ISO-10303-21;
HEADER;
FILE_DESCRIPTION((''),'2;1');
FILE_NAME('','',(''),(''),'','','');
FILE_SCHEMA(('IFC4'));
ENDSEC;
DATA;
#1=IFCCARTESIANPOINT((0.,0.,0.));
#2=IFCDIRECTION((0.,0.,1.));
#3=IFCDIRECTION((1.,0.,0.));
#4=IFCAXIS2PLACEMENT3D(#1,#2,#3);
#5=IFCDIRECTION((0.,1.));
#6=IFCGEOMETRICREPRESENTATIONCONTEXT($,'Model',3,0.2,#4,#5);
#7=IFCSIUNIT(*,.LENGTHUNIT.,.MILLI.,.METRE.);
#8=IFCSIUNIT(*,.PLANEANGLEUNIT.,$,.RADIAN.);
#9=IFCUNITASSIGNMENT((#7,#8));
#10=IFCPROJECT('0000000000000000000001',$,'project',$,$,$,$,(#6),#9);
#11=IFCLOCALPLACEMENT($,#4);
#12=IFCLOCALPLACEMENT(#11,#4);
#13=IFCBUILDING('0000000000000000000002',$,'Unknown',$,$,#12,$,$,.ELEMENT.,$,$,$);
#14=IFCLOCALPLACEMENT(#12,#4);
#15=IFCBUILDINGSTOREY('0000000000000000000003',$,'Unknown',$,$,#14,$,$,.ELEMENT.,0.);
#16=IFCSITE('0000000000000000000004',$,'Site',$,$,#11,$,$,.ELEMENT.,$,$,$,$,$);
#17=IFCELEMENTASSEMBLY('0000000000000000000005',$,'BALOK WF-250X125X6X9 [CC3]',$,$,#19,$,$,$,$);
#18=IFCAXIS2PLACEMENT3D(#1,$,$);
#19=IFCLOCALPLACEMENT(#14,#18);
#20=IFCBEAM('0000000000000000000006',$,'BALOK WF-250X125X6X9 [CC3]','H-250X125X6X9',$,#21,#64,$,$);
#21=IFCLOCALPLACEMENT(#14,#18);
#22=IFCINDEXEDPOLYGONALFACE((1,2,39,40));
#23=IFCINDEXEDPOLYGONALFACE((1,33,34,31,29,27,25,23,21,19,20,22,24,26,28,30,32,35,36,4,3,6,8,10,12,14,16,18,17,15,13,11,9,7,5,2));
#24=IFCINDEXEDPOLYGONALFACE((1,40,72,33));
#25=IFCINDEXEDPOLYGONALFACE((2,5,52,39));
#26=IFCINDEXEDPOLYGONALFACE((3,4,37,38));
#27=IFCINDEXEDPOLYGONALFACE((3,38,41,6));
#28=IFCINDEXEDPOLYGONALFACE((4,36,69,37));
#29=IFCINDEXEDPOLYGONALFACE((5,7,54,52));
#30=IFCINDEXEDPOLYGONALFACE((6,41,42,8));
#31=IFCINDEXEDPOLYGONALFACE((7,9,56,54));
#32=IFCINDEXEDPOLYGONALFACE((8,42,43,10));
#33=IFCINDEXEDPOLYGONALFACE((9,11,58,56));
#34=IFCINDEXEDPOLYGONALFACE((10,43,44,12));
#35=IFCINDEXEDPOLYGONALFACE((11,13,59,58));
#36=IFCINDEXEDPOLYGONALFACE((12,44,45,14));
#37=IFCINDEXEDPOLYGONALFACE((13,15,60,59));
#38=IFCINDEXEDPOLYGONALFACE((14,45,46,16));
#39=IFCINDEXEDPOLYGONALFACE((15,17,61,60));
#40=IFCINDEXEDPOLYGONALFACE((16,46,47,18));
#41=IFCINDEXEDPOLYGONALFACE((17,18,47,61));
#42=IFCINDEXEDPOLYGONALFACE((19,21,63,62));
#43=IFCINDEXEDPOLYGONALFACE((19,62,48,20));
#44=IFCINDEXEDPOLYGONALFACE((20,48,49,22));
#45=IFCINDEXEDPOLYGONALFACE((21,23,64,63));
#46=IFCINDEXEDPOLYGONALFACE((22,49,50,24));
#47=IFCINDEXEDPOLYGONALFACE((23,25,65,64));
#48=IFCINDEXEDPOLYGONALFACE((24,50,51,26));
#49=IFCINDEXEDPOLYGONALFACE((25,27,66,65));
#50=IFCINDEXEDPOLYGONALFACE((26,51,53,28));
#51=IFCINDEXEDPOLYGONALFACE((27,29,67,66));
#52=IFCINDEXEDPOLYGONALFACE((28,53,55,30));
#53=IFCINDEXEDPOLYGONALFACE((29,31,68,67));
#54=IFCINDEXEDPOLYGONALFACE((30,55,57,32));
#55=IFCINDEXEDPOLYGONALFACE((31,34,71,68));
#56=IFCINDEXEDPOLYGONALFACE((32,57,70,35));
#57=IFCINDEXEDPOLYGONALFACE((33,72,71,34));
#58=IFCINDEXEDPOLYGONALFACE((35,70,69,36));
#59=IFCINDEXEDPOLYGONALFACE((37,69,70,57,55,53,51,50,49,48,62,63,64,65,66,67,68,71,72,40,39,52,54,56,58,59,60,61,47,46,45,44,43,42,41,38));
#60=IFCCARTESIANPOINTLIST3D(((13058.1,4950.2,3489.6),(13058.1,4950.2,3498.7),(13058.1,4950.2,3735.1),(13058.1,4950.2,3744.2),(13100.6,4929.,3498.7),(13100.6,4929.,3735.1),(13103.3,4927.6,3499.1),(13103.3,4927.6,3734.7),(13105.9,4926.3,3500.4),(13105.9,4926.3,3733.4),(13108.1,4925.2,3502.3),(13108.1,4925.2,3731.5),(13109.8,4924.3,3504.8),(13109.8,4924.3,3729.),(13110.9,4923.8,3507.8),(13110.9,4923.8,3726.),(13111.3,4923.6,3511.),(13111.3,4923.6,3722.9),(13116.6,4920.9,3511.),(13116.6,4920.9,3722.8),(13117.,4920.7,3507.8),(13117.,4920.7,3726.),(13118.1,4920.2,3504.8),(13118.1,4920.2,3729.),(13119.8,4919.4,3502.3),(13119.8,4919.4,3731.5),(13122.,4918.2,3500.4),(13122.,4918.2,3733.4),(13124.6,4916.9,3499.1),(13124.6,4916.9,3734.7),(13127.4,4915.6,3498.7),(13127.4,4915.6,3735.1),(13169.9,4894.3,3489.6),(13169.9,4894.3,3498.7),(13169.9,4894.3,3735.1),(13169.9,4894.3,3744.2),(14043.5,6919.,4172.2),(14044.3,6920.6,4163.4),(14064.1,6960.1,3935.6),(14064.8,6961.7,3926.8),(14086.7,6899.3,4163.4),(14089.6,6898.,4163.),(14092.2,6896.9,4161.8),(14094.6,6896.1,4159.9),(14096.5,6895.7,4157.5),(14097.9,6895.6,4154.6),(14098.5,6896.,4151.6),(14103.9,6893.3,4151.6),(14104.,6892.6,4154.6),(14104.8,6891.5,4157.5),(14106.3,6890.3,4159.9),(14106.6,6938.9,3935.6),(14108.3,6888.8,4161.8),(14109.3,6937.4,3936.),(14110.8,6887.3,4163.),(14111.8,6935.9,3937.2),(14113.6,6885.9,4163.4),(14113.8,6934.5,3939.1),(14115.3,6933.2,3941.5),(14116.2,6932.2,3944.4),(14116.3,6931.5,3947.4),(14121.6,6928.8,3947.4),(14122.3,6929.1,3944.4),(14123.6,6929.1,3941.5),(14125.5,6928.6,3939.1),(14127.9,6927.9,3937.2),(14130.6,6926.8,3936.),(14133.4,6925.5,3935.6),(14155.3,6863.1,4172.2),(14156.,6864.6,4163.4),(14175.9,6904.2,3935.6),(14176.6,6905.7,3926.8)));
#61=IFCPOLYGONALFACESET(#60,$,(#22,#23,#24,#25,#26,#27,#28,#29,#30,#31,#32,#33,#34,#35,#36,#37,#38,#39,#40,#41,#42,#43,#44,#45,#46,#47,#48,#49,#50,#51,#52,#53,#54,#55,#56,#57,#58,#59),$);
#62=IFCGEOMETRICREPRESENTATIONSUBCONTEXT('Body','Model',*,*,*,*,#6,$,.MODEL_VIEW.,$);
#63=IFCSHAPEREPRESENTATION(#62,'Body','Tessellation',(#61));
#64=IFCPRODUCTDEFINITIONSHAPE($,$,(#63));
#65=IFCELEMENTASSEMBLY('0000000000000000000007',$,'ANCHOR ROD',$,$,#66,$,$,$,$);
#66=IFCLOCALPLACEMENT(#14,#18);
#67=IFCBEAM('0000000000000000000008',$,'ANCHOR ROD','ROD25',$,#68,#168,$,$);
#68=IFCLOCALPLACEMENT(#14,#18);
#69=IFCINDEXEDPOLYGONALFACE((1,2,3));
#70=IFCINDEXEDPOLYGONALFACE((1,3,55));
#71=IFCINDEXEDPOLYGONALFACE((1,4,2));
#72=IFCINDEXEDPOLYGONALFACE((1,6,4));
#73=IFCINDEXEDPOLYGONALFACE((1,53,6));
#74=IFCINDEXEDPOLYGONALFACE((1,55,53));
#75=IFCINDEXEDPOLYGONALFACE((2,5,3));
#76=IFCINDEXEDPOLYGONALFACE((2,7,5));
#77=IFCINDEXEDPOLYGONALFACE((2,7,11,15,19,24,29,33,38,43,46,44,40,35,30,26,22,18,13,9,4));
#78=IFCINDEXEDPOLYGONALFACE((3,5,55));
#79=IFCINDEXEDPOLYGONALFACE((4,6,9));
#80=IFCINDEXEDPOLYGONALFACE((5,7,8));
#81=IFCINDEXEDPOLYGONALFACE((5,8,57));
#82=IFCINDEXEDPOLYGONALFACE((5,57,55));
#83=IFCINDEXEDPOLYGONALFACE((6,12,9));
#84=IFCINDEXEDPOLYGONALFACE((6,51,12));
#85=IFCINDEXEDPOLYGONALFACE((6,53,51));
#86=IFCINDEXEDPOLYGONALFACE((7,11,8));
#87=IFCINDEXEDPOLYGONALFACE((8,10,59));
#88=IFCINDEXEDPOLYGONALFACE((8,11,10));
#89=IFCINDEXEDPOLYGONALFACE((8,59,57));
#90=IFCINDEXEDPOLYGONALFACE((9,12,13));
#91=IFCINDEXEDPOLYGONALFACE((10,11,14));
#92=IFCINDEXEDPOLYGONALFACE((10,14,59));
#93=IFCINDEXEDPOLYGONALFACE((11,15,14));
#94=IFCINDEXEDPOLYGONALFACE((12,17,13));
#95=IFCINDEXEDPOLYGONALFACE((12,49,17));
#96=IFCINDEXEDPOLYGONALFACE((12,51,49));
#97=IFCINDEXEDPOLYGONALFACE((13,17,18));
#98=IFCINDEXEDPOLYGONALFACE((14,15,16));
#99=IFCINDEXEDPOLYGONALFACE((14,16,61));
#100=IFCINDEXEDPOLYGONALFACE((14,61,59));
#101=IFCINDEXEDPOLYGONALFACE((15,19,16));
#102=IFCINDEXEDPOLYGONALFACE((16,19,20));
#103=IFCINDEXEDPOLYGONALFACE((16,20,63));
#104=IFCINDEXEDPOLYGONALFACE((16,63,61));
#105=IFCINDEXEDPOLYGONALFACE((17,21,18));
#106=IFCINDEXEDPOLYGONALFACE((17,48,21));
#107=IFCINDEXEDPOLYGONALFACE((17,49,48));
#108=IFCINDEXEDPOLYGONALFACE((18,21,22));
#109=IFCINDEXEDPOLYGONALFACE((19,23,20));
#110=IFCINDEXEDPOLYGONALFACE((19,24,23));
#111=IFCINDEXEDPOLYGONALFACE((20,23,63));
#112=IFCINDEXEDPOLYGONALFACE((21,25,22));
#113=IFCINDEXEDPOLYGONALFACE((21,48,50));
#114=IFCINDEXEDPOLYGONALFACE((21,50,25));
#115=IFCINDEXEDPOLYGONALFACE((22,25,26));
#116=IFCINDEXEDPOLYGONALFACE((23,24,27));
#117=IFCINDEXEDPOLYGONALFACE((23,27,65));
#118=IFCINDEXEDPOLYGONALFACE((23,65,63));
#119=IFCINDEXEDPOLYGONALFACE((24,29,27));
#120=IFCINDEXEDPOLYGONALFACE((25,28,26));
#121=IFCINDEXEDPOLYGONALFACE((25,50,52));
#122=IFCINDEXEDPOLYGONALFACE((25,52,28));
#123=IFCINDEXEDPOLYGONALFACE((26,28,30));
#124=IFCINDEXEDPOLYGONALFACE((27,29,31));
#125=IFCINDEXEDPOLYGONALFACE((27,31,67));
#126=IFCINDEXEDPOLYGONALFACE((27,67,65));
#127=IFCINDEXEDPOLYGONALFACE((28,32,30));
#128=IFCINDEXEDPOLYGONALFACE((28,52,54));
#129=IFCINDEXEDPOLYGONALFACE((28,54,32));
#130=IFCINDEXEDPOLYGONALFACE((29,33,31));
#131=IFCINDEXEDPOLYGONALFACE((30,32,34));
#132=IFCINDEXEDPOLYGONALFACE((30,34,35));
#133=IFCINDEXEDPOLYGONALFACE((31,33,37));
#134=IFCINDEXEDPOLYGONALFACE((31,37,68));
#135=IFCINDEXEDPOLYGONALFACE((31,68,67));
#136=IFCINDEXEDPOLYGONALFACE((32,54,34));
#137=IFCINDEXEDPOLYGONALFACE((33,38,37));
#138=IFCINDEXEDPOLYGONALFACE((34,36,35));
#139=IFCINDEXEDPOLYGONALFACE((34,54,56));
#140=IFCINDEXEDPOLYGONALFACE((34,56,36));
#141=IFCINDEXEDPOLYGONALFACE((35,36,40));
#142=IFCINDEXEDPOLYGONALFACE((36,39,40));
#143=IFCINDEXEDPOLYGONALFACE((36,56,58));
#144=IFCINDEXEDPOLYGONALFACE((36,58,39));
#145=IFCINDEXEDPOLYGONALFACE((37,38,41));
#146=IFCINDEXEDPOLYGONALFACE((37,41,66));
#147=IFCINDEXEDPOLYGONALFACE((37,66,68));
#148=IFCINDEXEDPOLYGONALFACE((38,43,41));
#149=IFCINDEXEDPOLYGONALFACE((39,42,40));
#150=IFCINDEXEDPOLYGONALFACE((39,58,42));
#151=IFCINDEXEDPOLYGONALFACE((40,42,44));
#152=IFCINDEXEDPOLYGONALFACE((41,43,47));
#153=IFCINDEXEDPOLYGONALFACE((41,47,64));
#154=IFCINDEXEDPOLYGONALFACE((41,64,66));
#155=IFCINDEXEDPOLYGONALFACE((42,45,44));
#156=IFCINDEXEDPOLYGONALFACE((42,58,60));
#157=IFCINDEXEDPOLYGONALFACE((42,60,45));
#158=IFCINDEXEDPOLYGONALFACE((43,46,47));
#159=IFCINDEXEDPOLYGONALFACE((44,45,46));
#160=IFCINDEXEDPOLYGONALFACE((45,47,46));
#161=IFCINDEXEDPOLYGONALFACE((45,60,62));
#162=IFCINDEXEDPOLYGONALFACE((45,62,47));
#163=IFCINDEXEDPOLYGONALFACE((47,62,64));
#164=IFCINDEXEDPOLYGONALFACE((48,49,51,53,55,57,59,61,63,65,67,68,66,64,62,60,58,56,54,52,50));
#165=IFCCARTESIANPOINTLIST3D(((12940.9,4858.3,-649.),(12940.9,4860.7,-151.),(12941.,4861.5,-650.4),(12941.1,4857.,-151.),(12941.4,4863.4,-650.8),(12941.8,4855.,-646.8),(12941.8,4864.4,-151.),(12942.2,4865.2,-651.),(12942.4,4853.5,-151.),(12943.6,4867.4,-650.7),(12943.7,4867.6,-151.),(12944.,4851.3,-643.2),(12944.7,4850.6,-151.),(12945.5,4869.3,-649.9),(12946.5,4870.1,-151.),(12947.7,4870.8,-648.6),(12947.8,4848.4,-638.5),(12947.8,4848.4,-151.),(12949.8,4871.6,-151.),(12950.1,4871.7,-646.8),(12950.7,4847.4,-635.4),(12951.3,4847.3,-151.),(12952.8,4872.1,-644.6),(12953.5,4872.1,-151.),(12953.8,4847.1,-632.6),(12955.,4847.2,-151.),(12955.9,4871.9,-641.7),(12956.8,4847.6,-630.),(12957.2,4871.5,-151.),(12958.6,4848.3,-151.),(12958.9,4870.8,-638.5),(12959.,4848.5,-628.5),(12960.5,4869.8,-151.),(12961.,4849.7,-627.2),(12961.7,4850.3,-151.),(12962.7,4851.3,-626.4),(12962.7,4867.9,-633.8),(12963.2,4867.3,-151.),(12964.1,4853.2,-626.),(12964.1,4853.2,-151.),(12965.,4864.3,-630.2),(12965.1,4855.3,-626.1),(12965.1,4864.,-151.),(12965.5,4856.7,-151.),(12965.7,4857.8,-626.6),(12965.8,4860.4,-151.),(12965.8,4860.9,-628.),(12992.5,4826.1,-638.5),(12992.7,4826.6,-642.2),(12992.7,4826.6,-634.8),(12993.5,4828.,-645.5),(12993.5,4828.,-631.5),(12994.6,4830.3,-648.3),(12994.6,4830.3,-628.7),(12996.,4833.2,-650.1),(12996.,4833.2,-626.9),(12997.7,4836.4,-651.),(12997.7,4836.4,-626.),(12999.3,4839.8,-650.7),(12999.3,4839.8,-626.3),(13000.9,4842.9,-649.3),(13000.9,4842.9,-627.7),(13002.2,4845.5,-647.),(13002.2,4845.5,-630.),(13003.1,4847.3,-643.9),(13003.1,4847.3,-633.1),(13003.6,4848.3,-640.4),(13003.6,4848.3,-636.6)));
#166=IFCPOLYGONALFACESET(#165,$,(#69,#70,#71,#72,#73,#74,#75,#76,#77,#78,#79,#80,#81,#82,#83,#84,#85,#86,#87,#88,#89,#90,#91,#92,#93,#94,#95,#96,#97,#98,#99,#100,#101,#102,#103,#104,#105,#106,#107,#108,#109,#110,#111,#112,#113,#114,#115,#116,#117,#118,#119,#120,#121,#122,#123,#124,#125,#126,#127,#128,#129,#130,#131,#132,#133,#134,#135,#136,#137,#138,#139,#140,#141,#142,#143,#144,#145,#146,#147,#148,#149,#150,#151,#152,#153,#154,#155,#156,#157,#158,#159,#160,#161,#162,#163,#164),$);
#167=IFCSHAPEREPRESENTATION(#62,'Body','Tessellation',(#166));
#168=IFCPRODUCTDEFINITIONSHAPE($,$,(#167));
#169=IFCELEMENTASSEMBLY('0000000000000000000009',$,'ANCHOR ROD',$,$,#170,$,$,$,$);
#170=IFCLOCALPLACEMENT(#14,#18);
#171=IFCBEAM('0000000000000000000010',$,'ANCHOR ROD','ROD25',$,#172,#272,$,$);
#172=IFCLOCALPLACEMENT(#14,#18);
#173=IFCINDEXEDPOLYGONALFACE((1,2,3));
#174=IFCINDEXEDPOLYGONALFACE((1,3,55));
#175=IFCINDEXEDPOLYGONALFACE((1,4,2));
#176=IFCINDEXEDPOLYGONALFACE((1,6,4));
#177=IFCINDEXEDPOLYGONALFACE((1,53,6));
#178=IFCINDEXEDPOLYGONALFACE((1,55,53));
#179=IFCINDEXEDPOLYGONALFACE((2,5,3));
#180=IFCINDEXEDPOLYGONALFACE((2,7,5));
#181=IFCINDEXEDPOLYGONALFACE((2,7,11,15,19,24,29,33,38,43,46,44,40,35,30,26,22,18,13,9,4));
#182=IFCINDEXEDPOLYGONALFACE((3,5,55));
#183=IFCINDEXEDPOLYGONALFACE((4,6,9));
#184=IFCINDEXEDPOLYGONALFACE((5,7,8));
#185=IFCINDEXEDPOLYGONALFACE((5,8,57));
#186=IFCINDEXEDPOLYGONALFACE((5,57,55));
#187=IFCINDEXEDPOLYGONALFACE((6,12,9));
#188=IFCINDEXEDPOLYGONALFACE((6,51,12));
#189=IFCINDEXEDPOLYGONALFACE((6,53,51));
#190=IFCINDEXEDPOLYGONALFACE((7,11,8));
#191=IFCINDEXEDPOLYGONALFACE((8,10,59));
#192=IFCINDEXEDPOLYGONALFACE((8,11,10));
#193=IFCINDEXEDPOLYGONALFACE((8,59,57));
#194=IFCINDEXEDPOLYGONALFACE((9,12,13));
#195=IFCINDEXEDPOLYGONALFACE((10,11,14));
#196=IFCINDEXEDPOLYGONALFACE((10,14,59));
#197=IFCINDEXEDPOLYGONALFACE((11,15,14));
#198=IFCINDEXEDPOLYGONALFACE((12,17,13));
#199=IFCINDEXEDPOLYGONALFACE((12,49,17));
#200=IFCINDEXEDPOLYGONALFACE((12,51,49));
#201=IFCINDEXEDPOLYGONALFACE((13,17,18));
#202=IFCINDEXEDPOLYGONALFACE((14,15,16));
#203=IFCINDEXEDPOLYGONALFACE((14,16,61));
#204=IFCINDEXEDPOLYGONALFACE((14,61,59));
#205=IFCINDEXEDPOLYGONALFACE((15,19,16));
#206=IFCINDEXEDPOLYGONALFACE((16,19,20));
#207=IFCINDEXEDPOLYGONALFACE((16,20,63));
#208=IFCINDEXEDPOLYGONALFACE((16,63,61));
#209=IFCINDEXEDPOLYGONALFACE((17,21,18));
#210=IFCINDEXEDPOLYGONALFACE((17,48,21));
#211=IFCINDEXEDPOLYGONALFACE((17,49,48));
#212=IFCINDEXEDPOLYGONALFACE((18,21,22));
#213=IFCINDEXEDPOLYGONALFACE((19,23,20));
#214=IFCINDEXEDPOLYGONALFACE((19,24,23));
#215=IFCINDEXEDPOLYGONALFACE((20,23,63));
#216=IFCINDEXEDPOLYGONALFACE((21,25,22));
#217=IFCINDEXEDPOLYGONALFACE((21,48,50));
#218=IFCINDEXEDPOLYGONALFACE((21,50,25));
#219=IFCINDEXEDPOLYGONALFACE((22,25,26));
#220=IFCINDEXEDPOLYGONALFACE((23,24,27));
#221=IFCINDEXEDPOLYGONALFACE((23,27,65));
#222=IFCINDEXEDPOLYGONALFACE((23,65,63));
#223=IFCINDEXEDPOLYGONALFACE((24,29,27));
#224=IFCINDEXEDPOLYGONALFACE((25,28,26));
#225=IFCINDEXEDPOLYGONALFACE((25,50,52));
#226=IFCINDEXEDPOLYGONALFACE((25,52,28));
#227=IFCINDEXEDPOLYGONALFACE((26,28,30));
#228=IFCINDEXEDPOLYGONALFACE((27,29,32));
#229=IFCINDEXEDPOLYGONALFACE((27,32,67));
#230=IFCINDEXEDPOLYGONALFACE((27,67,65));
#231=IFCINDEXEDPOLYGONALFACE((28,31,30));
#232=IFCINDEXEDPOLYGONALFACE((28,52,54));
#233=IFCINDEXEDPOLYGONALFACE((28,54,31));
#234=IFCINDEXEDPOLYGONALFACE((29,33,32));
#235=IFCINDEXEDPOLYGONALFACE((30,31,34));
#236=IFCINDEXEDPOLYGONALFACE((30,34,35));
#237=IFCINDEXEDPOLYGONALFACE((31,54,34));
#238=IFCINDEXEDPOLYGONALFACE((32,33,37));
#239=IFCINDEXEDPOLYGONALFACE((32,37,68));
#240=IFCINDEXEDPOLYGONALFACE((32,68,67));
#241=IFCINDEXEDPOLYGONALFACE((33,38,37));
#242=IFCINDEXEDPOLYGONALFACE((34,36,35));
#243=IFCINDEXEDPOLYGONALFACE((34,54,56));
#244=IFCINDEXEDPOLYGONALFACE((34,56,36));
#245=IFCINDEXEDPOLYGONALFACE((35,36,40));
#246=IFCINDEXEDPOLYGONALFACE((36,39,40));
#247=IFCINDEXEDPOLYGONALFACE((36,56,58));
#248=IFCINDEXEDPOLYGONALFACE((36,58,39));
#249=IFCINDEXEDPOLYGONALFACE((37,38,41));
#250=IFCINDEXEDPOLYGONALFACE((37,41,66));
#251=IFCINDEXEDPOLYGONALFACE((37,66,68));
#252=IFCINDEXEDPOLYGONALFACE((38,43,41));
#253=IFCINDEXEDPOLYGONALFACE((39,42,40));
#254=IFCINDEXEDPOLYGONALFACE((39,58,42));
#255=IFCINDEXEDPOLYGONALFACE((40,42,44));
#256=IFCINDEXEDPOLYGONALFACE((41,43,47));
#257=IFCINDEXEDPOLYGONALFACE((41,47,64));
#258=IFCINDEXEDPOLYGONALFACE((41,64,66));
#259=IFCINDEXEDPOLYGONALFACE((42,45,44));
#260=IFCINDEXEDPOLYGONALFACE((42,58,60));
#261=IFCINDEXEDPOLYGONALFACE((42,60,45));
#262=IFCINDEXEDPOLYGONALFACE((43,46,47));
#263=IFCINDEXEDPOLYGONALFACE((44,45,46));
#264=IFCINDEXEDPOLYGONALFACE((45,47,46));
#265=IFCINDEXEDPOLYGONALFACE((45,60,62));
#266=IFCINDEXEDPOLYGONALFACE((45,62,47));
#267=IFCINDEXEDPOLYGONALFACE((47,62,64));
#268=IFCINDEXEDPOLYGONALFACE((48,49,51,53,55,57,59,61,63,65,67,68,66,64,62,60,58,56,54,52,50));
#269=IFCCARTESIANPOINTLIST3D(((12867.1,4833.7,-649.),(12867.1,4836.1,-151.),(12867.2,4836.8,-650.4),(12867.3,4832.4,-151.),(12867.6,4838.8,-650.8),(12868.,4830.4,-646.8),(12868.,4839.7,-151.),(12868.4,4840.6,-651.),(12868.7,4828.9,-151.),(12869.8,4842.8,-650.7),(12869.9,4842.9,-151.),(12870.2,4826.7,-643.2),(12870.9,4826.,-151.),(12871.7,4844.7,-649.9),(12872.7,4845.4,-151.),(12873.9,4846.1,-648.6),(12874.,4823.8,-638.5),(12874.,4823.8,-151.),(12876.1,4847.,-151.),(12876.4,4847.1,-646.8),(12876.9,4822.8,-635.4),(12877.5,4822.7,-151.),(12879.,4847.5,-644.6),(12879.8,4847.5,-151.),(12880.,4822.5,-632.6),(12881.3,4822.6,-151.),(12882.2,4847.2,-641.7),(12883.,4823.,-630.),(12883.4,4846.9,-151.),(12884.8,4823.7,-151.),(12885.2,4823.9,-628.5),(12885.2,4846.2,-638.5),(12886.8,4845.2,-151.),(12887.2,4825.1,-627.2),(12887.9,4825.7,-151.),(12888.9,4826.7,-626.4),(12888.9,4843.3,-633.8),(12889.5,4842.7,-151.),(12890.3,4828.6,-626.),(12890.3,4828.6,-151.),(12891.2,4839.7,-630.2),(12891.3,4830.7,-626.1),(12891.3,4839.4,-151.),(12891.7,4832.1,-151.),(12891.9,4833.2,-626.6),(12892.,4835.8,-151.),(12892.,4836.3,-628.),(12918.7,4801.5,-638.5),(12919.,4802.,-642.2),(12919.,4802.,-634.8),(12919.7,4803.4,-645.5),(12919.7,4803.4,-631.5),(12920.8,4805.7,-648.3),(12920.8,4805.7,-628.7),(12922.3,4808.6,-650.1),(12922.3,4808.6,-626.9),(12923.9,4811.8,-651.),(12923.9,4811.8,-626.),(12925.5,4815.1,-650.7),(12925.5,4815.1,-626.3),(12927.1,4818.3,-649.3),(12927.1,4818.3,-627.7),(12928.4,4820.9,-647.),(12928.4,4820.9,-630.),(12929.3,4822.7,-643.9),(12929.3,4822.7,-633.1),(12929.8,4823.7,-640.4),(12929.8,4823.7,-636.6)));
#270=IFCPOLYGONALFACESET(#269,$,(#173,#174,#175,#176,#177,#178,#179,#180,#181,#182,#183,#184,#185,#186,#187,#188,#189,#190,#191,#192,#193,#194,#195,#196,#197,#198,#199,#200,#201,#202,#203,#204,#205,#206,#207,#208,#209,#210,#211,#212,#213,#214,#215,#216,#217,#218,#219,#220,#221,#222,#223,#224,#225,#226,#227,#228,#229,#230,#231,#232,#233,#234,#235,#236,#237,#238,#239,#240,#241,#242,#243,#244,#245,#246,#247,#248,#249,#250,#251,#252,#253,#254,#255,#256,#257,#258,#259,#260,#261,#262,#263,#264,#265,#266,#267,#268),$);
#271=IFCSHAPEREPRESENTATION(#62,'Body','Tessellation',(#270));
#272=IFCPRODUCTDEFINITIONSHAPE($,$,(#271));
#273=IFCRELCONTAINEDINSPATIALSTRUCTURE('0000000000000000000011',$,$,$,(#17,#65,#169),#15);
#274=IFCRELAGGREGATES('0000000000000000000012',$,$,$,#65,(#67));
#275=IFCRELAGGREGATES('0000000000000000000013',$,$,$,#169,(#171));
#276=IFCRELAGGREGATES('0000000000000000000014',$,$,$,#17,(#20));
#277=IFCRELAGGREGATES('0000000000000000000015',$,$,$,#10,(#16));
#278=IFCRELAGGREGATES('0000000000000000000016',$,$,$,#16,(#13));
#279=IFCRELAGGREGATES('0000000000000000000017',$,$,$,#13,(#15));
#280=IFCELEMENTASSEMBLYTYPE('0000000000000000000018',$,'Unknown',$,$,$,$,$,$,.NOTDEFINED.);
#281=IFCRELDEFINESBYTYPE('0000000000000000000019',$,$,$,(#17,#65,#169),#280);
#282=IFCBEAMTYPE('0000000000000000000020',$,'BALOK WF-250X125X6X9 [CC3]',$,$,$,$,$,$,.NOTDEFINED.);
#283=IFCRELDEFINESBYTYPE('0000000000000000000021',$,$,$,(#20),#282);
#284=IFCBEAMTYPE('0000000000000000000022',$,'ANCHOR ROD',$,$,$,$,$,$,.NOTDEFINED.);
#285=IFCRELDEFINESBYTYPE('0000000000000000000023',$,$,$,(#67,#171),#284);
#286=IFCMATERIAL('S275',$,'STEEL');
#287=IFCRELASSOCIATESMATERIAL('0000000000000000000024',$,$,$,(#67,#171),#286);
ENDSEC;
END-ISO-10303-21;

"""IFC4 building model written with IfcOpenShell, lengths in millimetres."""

from ifc_helpers import new_model, entity, si_unit, direction, frame, origin_with_axes, origin_2d_with_axis, place, context, subcontext, project, spatial, i_section, extrude, clip, halfspace, material, type_object, element, aggregate, save


model = new_model("IFC4")

# Units and contexts
model_context = context("Model", 3, precision=0.2, world=origin_with_axes(), true_north=direction((0.0, 1.0)))
body_context = subcontext(model_context, "Body", "Model", "MODEL_VIEW")
ifc_project = project(units=[si_unit("LENGTHUNIT", "METRE", prefix="MILLI"), si_unit("PLANEANGLEUNIT", "RADIAN")], contexts=[model_context])

# Site, building, storey
site_placement = place(None, origin_with_axes())
site = spatial("IfcSite", under=ifc_project, at=site_placement, Name="Site", CompositionType="ELEMENT")
building_placement = place(site_placement, origin_with_axes())
building = spatial("IfcBuilding", under=site, at=building_placement, Name="Unknown", CompositionType="ELEMENT")
storey_placement = place(building_placement, origin_with_axes())
storey = spatial("IfcBuildingStorey", under=building, at=storey_placement, Name="Unknown", CompositionType="ELEMENT", Elevation=0.0)

# Element assemblies, beams
element_assembly_type = type_object("IfcElementAssemblyType", Name="Unknown", PredefinedType="NOTDEFINED")
assembly_1_placement = place(storey_placement, frame((13099.5, 4893.4, 3610.6), z_axis=(0.89424, -0.447588, 0.0), x_axis=(0.439365, 0.87781, 0.190809)))
assembly_1 = element("IfcElementAssembly", 1, at=assembly_1_placement, inside=storey, type_object=element_assembly_type, Name="BALOK WF-250X125X6X9 [CC3]")
beam_type_1 = type_object("IfcBeamType", Name="BALOK WF-250X125X6X9 [CC3]", PredefinedType="NOTDEFINED")
beam_1_placement = place(assembly_1_placement, origin_with_axes())
beam_1 = element("IfcBeam", 2, at=beam_1_placement, type_object=beam_type_1, Name="BALOK WF-250X125X6X9 [CC3]", Description="H-250X125X6X9", context=body_context, shape_type="Clipping", body=[
    clip(clip(extrude(i_section(OverallWidth=125.0, OverallDepth=250.0, WebThickness=6.0, FlangeThickness=9.0, FilletRadius=12.0, FlangeEdgeRadius=0.0, FlangeSlope=0.0, at=origin_2d_with_axis()), frame((0.0, 0.0, 0.0), z_axis=(-1.0, 0.0, 0.0), x_axis=(0.0, 0.0, 1.0)), (0.0, 0.0, -1.0), 2300.0), halfspace(frame((6.5, -125.0, -62.5), z_axis=(-0.981634, 0.190772, 0.0), x_axis=(0.0, 0.0, 1.0)), False)), halfspace(frame((8.6, -125.0, -62.5), z_axis=(-0.981627, 0.190809, -0.000122), x_axis=(-0.000125, 0.0, 1.0)), False)),
])
assembly_2_placement = place(storey_placement, frame((12953.4, 4859.6, -151.0), z_axis=(-0.447009, -0.89453, 0.0), x_axis=(0.0, 0.0, -1.0)))
assembly_2 = element("IfcElementAssembly", 3, at=assembly_2_placement, inside=storey, type_object=element_assembly_type, Name="ANCHOR ROD")
ifc_material_1 = material(Name="S275", Category="STEEL")
beam_type_2 = type_object("IfcBeamType", Name="ANCHOR ROD", PredefinedType="NOTDEFINED")
beam_2_placement = place(assembly_2_placement, origin_with_axes())
beam_2 = element("IfcBeam", 4, at=beam_2_placement, type_object=beam_type_2, material=ifc_material_1, Name="ANCHOR ROD", Description="ROD25", context=body_context, shape_type="SolidModel", body=[
    entity("IfcSweptDiskSolid", entity("IfcIndexedPolyCurve", entity("IfcCartesianPointList3D", [[0.0, 0.0, 0.0], [487.5, 0.0, 0.0], [487.5, 50.0, 0.0]]), [entity("IfcLineIndex", [1, 2, 3])]), 12.5),
])
assembly_3_placement = place(storey_placement, frame((12879.6, 4835.0, -151.0), z_axis=(-0.447009, -0.89453, 0.0), x_axis=(0.0, 0.0, -1.0)))
assembly_3 = element("IfcElementAssembly", 5, at=assembly_3_placement, inside=storey, type_object=element_assembly_type, Name="ANCHOR ROD")
beam_3_placement = place(assembly_3_placement, origin_with_axes())
beam_3 = element("IfcBeam", 6, at=beam_3_placement, type_object=beam_type_2, material=ifc_material_1, Name="ANCHOR ROD", Description="ROD25", context=body_context, shape_type="SolidModel", body=[
    entity("IfcSweptDiskSolid", entity("IfcIndexedPolyCurve", entity("IfcCartesianPointList3D", [[0.0, 0.0, 0.0], [487.5, 0.0, 0.0], [487.5, 50.0, 0.0]]), [entity("IfcLineIndex", [1, 2, 3])]), 12.5),
])

aggregate(assembly_2, [beam_2])
aggregate(assembly_3, [beam_3])

aggregate(assembly_1, [beam_1])

save(model, "model.ifc")
